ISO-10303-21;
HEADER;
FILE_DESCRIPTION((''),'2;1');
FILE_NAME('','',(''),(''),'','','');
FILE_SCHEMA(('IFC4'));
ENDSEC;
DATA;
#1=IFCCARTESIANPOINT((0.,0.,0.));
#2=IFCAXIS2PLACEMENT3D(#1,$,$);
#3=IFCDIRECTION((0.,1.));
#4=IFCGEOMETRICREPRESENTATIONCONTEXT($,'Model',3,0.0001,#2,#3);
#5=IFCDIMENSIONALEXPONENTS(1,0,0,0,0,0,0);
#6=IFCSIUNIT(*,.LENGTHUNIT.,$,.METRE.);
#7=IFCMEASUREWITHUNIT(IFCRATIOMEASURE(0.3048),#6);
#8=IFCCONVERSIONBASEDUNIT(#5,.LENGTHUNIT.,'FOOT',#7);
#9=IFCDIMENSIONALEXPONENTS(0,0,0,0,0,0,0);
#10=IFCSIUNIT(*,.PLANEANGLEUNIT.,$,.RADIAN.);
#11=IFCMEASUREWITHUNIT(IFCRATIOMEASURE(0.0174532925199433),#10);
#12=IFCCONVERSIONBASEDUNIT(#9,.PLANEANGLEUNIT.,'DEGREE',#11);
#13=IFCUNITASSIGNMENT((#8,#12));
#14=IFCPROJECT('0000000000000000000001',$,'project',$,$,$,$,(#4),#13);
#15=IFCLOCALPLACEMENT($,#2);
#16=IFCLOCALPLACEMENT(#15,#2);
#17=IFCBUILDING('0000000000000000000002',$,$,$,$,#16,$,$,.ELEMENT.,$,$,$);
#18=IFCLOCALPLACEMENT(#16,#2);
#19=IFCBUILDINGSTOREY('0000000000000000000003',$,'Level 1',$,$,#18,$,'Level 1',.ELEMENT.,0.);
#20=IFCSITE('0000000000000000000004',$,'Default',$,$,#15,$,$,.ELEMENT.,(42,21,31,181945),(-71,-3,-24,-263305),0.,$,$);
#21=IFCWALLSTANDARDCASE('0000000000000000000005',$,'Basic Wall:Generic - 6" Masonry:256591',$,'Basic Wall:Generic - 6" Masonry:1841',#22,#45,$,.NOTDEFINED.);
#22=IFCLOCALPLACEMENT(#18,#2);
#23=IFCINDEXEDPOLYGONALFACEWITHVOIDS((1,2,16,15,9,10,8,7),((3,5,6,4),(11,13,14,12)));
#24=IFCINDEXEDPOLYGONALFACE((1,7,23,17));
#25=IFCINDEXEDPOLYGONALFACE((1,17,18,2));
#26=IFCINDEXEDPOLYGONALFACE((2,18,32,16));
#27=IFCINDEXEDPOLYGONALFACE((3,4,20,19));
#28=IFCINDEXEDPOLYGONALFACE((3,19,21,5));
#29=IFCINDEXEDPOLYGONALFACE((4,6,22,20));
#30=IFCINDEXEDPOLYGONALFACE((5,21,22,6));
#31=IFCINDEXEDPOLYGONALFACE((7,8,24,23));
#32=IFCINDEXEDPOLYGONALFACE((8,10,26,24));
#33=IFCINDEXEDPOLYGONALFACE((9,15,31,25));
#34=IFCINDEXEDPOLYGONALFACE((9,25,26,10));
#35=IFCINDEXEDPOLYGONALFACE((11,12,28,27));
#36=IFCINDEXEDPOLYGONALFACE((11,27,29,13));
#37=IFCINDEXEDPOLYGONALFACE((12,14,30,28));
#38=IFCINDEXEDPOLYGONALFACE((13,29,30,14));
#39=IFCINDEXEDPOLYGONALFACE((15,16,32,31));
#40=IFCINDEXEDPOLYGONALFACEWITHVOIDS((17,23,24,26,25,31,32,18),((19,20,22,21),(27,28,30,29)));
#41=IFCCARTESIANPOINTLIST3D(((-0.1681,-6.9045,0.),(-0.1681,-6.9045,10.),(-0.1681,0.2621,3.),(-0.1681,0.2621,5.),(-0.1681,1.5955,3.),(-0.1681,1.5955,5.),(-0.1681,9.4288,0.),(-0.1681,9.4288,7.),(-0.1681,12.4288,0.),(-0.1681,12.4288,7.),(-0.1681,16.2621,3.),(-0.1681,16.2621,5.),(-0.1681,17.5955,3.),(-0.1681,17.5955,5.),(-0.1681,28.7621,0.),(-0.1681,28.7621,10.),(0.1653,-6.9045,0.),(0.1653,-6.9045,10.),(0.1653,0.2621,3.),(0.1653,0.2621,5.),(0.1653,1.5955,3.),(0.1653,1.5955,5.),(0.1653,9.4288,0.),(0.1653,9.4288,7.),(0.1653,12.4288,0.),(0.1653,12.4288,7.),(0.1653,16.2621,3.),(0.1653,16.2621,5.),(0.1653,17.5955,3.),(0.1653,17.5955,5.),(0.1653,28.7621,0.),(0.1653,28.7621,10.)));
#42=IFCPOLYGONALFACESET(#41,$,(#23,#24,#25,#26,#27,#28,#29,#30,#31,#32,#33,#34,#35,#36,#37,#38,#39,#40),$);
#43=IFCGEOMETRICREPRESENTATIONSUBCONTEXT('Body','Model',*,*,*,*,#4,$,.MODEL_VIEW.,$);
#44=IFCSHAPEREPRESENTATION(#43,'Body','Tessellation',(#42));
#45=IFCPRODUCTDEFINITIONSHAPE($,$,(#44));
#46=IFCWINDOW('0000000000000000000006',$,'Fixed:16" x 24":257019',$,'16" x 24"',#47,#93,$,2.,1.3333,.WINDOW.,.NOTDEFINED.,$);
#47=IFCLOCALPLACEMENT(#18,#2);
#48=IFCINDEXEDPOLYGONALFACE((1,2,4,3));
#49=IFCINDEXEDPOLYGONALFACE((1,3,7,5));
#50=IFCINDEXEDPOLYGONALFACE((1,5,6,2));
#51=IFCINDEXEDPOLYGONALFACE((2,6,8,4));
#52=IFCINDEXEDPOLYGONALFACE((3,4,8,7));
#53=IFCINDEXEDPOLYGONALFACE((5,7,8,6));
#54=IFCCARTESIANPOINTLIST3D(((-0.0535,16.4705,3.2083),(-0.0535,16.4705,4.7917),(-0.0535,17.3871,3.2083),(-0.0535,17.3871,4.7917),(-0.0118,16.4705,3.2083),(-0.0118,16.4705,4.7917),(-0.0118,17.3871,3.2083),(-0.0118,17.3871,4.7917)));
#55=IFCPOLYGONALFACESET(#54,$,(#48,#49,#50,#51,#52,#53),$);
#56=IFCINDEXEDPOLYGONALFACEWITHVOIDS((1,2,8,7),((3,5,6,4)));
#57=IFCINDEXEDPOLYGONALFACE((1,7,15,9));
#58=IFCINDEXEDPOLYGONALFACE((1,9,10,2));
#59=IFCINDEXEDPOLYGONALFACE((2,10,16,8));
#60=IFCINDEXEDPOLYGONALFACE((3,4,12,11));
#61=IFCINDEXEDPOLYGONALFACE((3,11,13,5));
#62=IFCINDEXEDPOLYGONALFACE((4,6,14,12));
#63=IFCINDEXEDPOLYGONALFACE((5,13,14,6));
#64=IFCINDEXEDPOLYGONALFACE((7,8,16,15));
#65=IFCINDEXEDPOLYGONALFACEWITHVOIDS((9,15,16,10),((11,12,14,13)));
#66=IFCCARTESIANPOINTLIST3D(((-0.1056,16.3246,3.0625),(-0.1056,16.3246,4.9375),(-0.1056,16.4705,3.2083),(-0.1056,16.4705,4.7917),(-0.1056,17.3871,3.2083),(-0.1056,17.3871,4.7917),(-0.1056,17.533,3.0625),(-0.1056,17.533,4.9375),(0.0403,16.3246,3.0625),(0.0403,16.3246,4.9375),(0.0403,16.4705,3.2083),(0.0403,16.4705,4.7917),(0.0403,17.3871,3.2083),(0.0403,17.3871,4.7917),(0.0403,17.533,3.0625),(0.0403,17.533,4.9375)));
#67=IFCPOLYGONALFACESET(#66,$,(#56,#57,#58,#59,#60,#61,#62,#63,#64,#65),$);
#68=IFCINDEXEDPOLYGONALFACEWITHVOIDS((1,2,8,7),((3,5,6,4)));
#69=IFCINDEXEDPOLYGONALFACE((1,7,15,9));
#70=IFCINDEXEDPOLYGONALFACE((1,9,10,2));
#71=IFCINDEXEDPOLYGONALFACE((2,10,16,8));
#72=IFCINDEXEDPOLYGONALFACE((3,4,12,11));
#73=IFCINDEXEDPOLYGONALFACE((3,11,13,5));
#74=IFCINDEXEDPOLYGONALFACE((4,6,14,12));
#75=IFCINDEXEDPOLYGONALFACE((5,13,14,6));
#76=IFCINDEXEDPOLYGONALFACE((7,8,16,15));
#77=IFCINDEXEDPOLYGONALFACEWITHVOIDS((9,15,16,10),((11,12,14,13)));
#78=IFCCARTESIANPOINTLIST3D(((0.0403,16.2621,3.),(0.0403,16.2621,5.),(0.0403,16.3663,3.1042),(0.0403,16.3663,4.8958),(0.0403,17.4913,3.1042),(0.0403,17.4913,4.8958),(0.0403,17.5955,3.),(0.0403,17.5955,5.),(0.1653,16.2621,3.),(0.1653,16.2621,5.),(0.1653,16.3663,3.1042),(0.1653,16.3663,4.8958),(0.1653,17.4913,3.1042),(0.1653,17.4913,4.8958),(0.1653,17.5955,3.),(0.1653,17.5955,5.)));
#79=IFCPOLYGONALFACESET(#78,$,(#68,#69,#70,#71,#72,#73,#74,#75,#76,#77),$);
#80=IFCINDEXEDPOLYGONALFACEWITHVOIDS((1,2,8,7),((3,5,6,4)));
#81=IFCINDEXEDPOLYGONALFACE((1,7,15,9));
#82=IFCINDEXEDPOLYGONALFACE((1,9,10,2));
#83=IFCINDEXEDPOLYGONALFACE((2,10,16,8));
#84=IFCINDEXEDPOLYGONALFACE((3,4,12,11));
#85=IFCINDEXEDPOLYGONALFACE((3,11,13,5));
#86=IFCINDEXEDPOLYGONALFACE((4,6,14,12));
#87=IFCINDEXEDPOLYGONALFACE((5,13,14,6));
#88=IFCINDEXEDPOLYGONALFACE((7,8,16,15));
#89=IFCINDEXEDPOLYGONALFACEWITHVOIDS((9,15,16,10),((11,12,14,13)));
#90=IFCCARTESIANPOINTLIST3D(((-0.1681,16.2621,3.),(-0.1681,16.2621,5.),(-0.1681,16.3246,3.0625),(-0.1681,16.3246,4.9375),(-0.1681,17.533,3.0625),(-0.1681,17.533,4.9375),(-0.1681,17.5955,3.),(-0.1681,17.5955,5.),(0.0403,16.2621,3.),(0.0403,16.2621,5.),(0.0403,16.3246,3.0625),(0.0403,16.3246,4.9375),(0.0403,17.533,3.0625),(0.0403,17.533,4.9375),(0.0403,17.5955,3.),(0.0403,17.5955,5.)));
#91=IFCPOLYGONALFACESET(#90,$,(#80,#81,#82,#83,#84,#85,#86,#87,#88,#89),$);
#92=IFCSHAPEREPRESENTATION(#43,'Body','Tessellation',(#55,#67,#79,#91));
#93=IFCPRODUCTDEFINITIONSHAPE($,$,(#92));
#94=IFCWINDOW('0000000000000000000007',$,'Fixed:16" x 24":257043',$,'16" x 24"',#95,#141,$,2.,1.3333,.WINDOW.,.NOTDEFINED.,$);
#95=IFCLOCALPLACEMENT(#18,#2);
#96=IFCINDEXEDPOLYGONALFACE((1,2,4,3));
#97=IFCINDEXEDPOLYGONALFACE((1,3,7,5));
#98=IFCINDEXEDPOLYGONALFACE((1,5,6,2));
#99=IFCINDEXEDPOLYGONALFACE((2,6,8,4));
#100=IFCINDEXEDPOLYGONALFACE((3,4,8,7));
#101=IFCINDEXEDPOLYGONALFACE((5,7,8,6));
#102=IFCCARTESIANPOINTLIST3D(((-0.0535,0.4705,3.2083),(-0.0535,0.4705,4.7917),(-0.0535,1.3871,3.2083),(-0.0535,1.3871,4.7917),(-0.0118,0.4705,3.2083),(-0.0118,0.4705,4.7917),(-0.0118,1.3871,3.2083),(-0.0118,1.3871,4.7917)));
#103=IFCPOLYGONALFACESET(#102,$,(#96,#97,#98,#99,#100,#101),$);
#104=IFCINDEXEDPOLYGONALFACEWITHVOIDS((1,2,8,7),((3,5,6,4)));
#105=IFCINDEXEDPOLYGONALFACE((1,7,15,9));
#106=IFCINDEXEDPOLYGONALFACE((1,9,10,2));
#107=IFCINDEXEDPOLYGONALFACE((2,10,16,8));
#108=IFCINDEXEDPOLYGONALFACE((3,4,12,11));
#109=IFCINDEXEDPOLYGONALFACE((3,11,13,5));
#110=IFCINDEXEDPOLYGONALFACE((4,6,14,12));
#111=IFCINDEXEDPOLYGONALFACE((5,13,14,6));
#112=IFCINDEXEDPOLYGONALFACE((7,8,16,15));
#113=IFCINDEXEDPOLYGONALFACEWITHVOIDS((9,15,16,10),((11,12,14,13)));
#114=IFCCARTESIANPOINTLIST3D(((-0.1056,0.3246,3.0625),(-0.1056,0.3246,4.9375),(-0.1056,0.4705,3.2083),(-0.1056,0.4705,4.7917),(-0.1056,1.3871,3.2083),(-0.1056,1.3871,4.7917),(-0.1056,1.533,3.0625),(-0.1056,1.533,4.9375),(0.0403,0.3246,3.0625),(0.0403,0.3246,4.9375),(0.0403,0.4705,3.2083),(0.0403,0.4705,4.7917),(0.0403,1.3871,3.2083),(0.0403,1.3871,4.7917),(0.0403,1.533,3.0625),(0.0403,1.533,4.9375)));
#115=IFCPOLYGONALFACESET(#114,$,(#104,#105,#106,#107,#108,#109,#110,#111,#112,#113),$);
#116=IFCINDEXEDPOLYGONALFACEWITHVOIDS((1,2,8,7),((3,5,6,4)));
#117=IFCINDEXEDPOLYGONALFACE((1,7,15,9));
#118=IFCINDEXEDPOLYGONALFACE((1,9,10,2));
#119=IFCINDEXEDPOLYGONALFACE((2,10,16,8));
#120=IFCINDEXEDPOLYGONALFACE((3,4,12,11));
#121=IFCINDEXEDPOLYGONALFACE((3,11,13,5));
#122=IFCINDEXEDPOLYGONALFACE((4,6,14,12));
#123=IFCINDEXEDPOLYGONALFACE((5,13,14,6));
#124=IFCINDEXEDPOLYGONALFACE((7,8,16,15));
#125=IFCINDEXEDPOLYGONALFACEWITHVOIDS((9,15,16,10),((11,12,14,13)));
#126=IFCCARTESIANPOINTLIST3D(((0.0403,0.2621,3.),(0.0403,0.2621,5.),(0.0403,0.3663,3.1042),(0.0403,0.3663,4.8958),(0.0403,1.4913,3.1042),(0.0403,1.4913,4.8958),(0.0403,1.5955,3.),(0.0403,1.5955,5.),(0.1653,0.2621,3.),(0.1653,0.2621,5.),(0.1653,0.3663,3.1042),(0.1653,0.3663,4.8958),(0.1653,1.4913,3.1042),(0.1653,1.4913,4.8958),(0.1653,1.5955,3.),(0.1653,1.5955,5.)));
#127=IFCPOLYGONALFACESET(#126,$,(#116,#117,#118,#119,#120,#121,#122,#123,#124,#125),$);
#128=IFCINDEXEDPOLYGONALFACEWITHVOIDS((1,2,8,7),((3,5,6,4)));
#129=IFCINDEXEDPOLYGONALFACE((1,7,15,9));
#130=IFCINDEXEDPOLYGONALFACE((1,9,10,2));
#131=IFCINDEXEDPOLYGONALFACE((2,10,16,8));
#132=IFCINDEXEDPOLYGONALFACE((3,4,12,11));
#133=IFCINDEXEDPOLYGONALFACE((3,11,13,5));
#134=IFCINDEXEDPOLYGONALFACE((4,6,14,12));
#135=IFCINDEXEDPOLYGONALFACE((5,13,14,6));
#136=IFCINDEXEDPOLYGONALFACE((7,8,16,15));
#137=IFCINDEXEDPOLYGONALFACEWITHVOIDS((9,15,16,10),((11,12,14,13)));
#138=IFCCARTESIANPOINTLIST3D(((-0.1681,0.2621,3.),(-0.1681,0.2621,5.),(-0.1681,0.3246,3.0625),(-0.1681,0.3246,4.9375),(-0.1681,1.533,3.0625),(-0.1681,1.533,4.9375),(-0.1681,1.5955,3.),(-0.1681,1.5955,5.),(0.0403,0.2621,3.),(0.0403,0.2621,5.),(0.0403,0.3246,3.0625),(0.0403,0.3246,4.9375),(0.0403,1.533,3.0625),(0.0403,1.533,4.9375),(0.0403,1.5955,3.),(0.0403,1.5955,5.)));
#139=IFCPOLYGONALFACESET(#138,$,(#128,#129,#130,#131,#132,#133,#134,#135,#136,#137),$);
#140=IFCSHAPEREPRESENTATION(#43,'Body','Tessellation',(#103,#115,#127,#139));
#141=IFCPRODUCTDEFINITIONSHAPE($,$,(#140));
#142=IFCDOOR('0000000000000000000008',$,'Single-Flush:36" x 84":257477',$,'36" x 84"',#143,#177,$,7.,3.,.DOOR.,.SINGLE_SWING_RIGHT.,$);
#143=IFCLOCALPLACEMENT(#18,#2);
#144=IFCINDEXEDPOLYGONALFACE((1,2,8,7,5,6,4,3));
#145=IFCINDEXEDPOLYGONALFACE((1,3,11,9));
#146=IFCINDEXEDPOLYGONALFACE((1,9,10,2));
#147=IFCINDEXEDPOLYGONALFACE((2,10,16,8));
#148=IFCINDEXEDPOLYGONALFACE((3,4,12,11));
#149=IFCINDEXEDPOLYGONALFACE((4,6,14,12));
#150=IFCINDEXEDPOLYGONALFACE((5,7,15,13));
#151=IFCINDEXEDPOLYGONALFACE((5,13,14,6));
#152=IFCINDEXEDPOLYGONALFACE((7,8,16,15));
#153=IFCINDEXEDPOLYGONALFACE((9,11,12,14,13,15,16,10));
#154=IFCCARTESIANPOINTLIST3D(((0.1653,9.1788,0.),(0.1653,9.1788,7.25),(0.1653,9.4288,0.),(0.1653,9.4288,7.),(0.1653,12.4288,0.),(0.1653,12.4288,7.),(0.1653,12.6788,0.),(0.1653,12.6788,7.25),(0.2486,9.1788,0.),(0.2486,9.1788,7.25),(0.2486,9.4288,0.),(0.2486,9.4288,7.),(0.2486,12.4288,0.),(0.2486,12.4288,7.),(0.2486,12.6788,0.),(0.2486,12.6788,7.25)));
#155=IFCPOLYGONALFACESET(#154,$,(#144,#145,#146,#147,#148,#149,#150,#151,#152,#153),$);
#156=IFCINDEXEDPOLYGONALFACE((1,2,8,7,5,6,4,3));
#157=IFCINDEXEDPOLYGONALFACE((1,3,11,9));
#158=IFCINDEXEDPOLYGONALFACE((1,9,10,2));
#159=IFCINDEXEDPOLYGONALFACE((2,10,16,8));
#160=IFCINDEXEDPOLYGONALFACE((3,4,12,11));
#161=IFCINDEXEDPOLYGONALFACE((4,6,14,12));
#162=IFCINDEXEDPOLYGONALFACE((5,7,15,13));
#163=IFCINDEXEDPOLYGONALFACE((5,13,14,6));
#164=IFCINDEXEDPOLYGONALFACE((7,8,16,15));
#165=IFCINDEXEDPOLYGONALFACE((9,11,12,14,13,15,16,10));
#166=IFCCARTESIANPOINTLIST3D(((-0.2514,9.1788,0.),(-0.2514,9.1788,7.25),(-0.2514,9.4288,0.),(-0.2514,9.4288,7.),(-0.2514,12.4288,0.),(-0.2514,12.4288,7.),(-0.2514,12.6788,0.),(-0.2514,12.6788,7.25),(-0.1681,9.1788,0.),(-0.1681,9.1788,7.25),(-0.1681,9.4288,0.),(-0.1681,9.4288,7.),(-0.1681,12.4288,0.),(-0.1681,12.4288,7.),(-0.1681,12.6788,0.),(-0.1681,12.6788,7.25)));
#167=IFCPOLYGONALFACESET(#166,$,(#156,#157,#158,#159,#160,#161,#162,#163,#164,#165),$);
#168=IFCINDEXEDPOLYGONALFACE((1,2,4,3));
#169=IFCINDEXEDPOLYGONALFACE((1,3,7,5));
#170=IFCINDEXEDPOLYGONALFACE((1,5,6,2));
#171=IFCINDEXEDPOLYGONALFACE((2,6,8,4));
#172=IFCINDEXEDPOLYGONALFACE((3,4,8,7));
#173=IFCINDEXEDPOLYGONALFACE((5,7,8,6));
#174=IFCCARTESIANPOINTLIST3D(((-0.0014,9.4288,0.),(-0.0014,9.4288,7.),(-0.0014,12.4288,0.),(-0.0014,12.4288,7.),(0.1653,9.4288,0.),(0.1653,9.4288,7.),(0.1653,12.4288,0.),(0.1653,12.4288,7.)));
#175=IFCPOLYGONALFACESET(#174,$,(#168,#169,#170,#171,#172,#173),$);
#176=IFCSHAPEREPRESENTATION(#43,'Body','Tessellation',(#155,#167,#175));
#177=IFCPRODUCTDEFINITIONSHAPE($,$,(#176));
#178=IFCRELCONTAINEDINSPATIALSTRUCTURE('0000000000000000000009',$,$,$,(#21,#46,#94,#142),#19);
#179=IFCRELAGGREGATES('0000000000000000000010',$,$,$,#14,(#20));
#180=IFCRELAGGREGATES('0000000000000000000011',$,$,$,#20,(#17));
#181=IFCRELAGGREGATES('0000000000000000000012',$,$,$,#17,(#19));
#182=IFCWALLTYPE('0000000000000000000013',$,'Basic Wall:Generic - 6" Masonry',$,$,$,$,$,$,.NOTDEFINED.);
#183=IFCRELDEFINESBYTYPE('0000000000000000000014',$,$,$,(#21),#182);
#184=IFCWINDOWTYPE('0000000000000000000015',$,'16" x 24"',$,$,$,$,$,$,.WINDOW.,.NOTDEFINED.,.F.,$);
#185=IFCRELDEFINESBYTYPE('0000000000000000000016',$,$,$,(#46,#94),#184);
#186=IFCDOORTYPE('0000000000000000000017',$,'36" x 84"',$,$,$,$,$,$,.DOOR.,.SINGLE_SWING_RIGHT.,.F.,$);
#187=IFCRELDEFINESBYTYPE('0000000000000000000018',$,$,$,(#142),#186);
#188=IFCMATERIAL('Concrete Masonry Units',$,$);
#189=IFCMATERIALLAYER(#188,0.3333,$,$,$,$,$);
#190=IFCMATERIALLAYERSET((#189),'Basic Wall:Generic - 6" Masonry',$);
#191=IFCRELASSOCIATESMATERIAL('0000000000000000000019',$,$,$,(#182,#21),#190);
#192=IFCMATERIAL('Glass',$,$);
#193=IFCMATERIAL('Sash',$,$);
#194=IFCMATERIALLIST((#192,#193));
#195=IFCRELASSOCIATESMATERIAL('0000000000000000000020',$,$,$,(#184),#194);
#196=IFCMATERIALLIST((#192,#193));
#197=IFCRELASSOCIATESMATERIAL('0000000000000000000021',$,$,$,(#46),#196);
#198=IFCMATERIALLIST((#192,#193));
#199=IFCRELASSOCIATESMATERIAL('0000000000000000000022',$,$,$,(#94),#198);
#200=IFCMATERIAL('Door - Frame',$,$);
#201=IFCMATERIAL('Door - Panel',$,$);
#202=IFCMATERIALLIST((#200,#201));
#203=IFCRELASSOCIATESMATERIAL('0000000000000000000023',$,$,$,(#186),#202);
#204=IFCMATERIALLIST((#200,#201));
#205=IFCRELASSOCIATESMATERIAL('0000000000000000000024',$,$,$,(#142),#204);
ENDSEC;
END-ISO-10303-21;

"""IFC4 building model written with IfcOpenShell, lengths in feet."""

from ifc_helpers import new_model, entity, si_unit, converted_unit, direction, frame, frame_2d, origin, origin_2d_with_axis, place, context, subcontext, project, spatial, polyline, rectangle, outline, extrude, source, transform, mapped, material, material_list, layer, layer_set, layer_usage, type_object, type_shapes, element, fill, save


model = new_model("IFC4")

# Units and contexts
model_context = context("Model", 3, precision=0.0001, world=origin(), true_north=direction((0.0, 1.0)))
body_context = subcontext(model_context, "Body", "Model", "MODEL_VIEW")
ifc_project = project(units=[converted_unit("LENGTHUNIT", "FOOT", entity("IfcRatioMeasure", 0.3048), si_unit("LENGTHUNIT", "METRE"), dimensions=[1, 0, 0, 0, 0, 0, 0]), converted_unit("PLANEANGLEUNIT", "DEGREE", entity("IfcRatioMeasure", 0.0174532925199433), si_unit("PLANEANGLEUNIT", "RADIAN"), dimensions=[0, 0, 0, 0, 0, 0, 0])], contexts=[model_context])

# Site, building, storey
site_placement = place(None, origin())
site = spatial("IfcSite", under=ifc_project, at=site_placement, Name="Default", CompositionType="ELEMENT", RefLatitude=(42, 21, 31, 181945), RefLongitude=(-71, -3, -24, -263305), RefElevation=0.0)
building_placement = place(site_placement, origin())
building = spatial("IfcBuilding", under=site, at=building_placement, CompositionType="ELEMENT")
storey_placement = place(building_placement, origin())
storey = spatial("IfcBuildingStorey", under=building, at=storey_placement, Name="Level 1", LongName="Level 1", CompositionType="ELEMENT", Elevation=0.0)

# Shared definitions
wall_placement = place(storey_placement, frame((-0.0014, -6.9045, 0.0), z_axis=(0.0, 0.0, 1.0), x_axis=(0.0, 1.0, 0.0)))

# Wall, openings, windows, door
ifc_material_1 = material(Name="Concrete Masonry Units")
ifc_layer = layer(ifc_material_1, 0.3333)
ifc_layer_set = layer_set([ifc_layer], Name="Basic Wall:Generic - 6\" Masonry")
ifc_layer_usage = layer_usage(ifc_layer_set, "AXIS2", "NEGATIVE", 0.1667)
wall_type = type_object("IfcWallType", Name="Basic Wall:Generic - 6\" Masonry", PredefinedType="NOTDEFINED", material=ifc_layer_set)
wall = element("IfcWallStandardCase", 1, at=wall_placement, inside=storey, type_object=wall_type, material=ifc_layer_usage, Name="Basic Wall:Generic - 6\" Masonry:256591", ObjectType="Basic Wall:Generic - 6\" Masonry:1841", PredefinedType="NOTDEFINED", context=body_context, shape_type="SweptSolid", body=[
    extrude(rectangle(XDim=35.6667, YDim=0.3333, at=frame_2d((17.8333, 0.0), x_axis=(-1.0, 0.0))), origin(), (0.0, 0.0, 1.0), 10.0),
])
opening_1_placement = place(wall_placement, frame((19.3333, 0.1667, 0.0)))
opening_1 = element("IfcOpeningElement", 2, at=opening_1_placement, cuts=wall, ObjectType="Opening", PredefinedType="OPENING", context=body_context, shape_type="SweptSolid", body=[
    extrude(rectangle(XDim=3.0, YDim=7.0, at=frame_2d((3.5, 1.5), x_axis=(0.0, 1.0))), frame((0.0, 0.0, 0.0), z_axis=(0.0, -1.0, 0.0), x_axis=(0.0, 0.0, 1.0)), (0.0, 0.0, 1.0), 0.3333),
])
opening_2_placement = place(wall_placement, frame((23.1667, -0.1667, 3.0)))
opening_2 = element("IfcOpeningElement", 3, at=opening_2_placement, cuts=wall, ObjectType="Opening", PredefinedType="OPENING", context=body_context, shape_type="SweptSolid", body=[
    extrude(rectangle(XDim=2.0, YDim=1.3333, at=frame_2d((1.0, 0.6667), x_axis=(-1.0, 0.0))), frame((0.0, 0.0, 0.0), z_axis=(0.0, 1.0, 0.0), x_axis=(0.0, 0.0, 1.0)), (0.0, 0.0, 1.0), 0.3333),
])
opening_3_placement = place(wall_placement, frame((7.1667, -0.1667, 3.0)))
opening_3 = element("IfcOpeningElement", 4, at=opening_3_placement, cuts=wall, ObjectType="Opening", PredefinedType="OPENING", context=body_context, shape_type="SweptSolid", body=[
    extrude(rectangle(XDim=2.0, YDim=1.3333, at=frame_2d((1.0, 0.6667), x_axis=(-1.0, 0.0))), frame((0.0, 0.0, 0.0), z_axis=(0.0, 1.0, 0.0), x_axis=(0.0, 0.0, 1.0)), (0.0, 0.0, 1.0), 0.3333),
])
ifc_material_2 = material(Name="Glass")
ifc_material_3 = material(Name="Sash")
ifc_material_list_1 = material_list([ifc_material_2, ifc_material_3])
ifc_material_list_2 = material_list([ifc_material_2, ifc_material_3])
window_type = type_object("IfcWindowType", Name="16\" x 24\"", ParameterTakesPrecedence=False, PartitioningType="NOTDEFINED", PredefinedType="WINDOW", material=ifc_material_list_2)
shared_shape_1 = source(origin(), body_context, "Body", "SweptSolid", [
    extrude(rectangle(XDim=0.0417, YDim=0.9167, at=origin_2d_with_axis()), frame((0.6667, 0.1979, 0.2083), z_axis=(0.0, 0.0, 1.0), x_axis=(0.0, 1.0, 0.0)), (0.0, 0.0, 1.0), 1.5833),
    extrude(outline(polyline([(-0.6042, -0.9375), (0.6042, -0.9375), (0.6042, 0.9375), (-0.6042, 0.9375), (-0.6042, -0.9375)]), holes=[polyline([(-0.4583, -0.7917), (-0.4583, 0.7917), (0.4583, 0.7917), (0.4583, -0.7917), (-0.4583, -0.7917)])]), frame((0.6667, 0.125, 1.0), z_axis=(0.0, 1.0, 0.0), x_axis=(1.0, 0.0, 0.0)), (0.0, 0.0, 1.0), 0.1458),
    extrude(outline(polyline([(-0.6667, -1.0), (0.6667, -1.0), (0.6667, 1.0), (-0.6667, 1.0), (-0.6667, -1.0)]), holes=[polyline([(-0.5625, -0.8958), (-0.5625, 0.8958), (0.5625, 0.8958), (0.5625, -0.8958), (-0.5625, -0.8958)])]), frame((0.6667, 0.0, 1.0), z_axis=(0.0, 1.0, 0.0), x_axis=(1.0, 0.0, 0.0)), (0.0, 0.0, 1.0), 0.125),
    extrude(outline(polyline([(-1.0, -0.6667), (1.0, -0.6667), (1.0, 0.6667), (-1.0, 0.6667), (-1.0, -0.6667)]), holes=[polyline([(-0.9375, -0.6042), (-0.9375, 0.6042), (0.9375, 0.6042), (0.9375, -0.6042), (-0.9375, -0.6042)])]), frame((0.6667, 0.125, 1.0), z_axis=(0.0, 1.0, 0.0), x_axis=(0.0, 0.0, -1.0)), (0.0, 0.0, 1.0), 0.2083),
])
type_shapes(window_type, [shared_shape_1])
window_1_placement = place(opening_2_placement, origin())
window_1 = element("IfcWindow", 5, at=window_1_placement, inside=storey, type_object=window_type, material=ifc_material_list_1, Name="Fixed:16\" x 24\":257019", ObjectType="16\" x 24\"", OverallHeight=2.0, OverallWidth=1.3333, PartitioningType="NOTDEFINED", PredefinedType="WINDOW", context=body_context, shape_type="MappedRepresentation", body=[
    mapped(shared_shape_1, transform((0.0, 0.0, 0.0), scale=1.0)),
])
fill(opening_2, window_1)
ifc_material_list_3 = material_list([ifc_material_2, ifc_material_3])
window_2_placement = place(opening_3_placement, origin())
window_2 = element("IfcWindow", 6, at=window_2_placement, inside=storey, type_object=window_type, material=ifc_material_list_3, Name="Fixed:16\" x 24\":257043", ObjectType="16\" x 24\"", OverallHeight=2.0, OverallWidth=1.3333, PartitioningType="NOTDEFINED", PredefinedType="WINDOW", context=body_context, shape_type="MappedRepresentation", body=[
    mapped(shared_shape_1, transform((0.0, 0.0, 0.0), scale=1.0)),
])
fill(opening_3, window_2)
ifc_material_4 = material(Name="Door - Frame")
ifc_material_5 = material(Name="Door - Panel")
ifc_material_list_4 = material_list([ifc_material_4, ifc_material_5])
ifc_material_list_5 = material_list([ifc_material_4, ifc_material_5])
door_type = type_object("IfcDoorType", Name="36\" x 84\"", OperationType="SINGLE_SWING_RIGHT", ParameterTakesPrecedence=False, PredefinedType="DOOR", material=ifc_material_list_5)
shared_shape_2 = source(origin(), body_context, "Body", "SweptSolid", [
    extrude(outline(polyline([(-1.75, -3.6875), (1.75, -3.6875), (1.75, 3.5625), (1.5, 3.5625), (1.5, -3.4375), (-1.5, -3.4375), (-1.5, 3.5625), (-1.75, 3.5625), (-1.75, -3.6875)])), frame((1.5, 0.3333, 3.5625), z_axis=(0.0, 1.0, 0.0), x_axis=(1.0, 0.0, 0.0)), (0.0, 0.0, 1.0), 0.0833),
    extrude(outline(polyline([(-3.6875, -1.75), (3.5625, -1.75), (3.5625, -1.5), (-3.4375, -1.5), (-3.4375, 1.5), (3.5625, 1.5), (3.5625, 1.75), (-3.6875, 1.75), (-3.6875, -1.75)])), frame((1.5, -0.0833, 3.5625), z_axis=(0.0, 1.0, 0.0), x_axis=(0.0, 0.0, -1.0)), (0.0, 0.0, 1.0), 0.0833),
    extrude(rectangle(XDim=0.1667, YDim=3.0, at=frame_2d((0.0, 0.0), x_axis=(1.0, 0.0))), frame((1.5, 0.25, 0.0), z_axis=(0.0, 0.0, 1.0), x_axis=(0.0, 1.0, 0.0)), (0.0, 0.0, 1.0), 7.0),
])
type_shapes(door_type, [shared_shape_2])
door_placement = place(opening_1_placement, frame((0.0, 0.0, 0.0), z_axis=(0.0, 0.0, 1.0), x_axis=(-1.0, 0.0, 0.0)))
door = element("IfcDoor", 7, at=door_placement, inside=storey, type_object=door_type, material=ifc_material_list_4, Name="Single-Flush:36\" x 84\":257477", ObjectType="36\" x 84\"", OperationType="SINGLE_SWING_RIGHT", OverallHeight=7.0, OverallWidth=3.0, PredefinedType="DOOR", context=body_context, shape_type="MappedRepresentation", body=[
    mapped(shared_shape_2, transform((0.0, 0.0, 0.0), scale=1.0)),
])
fill(opening_1, door)

save(model, "model.ifc")
